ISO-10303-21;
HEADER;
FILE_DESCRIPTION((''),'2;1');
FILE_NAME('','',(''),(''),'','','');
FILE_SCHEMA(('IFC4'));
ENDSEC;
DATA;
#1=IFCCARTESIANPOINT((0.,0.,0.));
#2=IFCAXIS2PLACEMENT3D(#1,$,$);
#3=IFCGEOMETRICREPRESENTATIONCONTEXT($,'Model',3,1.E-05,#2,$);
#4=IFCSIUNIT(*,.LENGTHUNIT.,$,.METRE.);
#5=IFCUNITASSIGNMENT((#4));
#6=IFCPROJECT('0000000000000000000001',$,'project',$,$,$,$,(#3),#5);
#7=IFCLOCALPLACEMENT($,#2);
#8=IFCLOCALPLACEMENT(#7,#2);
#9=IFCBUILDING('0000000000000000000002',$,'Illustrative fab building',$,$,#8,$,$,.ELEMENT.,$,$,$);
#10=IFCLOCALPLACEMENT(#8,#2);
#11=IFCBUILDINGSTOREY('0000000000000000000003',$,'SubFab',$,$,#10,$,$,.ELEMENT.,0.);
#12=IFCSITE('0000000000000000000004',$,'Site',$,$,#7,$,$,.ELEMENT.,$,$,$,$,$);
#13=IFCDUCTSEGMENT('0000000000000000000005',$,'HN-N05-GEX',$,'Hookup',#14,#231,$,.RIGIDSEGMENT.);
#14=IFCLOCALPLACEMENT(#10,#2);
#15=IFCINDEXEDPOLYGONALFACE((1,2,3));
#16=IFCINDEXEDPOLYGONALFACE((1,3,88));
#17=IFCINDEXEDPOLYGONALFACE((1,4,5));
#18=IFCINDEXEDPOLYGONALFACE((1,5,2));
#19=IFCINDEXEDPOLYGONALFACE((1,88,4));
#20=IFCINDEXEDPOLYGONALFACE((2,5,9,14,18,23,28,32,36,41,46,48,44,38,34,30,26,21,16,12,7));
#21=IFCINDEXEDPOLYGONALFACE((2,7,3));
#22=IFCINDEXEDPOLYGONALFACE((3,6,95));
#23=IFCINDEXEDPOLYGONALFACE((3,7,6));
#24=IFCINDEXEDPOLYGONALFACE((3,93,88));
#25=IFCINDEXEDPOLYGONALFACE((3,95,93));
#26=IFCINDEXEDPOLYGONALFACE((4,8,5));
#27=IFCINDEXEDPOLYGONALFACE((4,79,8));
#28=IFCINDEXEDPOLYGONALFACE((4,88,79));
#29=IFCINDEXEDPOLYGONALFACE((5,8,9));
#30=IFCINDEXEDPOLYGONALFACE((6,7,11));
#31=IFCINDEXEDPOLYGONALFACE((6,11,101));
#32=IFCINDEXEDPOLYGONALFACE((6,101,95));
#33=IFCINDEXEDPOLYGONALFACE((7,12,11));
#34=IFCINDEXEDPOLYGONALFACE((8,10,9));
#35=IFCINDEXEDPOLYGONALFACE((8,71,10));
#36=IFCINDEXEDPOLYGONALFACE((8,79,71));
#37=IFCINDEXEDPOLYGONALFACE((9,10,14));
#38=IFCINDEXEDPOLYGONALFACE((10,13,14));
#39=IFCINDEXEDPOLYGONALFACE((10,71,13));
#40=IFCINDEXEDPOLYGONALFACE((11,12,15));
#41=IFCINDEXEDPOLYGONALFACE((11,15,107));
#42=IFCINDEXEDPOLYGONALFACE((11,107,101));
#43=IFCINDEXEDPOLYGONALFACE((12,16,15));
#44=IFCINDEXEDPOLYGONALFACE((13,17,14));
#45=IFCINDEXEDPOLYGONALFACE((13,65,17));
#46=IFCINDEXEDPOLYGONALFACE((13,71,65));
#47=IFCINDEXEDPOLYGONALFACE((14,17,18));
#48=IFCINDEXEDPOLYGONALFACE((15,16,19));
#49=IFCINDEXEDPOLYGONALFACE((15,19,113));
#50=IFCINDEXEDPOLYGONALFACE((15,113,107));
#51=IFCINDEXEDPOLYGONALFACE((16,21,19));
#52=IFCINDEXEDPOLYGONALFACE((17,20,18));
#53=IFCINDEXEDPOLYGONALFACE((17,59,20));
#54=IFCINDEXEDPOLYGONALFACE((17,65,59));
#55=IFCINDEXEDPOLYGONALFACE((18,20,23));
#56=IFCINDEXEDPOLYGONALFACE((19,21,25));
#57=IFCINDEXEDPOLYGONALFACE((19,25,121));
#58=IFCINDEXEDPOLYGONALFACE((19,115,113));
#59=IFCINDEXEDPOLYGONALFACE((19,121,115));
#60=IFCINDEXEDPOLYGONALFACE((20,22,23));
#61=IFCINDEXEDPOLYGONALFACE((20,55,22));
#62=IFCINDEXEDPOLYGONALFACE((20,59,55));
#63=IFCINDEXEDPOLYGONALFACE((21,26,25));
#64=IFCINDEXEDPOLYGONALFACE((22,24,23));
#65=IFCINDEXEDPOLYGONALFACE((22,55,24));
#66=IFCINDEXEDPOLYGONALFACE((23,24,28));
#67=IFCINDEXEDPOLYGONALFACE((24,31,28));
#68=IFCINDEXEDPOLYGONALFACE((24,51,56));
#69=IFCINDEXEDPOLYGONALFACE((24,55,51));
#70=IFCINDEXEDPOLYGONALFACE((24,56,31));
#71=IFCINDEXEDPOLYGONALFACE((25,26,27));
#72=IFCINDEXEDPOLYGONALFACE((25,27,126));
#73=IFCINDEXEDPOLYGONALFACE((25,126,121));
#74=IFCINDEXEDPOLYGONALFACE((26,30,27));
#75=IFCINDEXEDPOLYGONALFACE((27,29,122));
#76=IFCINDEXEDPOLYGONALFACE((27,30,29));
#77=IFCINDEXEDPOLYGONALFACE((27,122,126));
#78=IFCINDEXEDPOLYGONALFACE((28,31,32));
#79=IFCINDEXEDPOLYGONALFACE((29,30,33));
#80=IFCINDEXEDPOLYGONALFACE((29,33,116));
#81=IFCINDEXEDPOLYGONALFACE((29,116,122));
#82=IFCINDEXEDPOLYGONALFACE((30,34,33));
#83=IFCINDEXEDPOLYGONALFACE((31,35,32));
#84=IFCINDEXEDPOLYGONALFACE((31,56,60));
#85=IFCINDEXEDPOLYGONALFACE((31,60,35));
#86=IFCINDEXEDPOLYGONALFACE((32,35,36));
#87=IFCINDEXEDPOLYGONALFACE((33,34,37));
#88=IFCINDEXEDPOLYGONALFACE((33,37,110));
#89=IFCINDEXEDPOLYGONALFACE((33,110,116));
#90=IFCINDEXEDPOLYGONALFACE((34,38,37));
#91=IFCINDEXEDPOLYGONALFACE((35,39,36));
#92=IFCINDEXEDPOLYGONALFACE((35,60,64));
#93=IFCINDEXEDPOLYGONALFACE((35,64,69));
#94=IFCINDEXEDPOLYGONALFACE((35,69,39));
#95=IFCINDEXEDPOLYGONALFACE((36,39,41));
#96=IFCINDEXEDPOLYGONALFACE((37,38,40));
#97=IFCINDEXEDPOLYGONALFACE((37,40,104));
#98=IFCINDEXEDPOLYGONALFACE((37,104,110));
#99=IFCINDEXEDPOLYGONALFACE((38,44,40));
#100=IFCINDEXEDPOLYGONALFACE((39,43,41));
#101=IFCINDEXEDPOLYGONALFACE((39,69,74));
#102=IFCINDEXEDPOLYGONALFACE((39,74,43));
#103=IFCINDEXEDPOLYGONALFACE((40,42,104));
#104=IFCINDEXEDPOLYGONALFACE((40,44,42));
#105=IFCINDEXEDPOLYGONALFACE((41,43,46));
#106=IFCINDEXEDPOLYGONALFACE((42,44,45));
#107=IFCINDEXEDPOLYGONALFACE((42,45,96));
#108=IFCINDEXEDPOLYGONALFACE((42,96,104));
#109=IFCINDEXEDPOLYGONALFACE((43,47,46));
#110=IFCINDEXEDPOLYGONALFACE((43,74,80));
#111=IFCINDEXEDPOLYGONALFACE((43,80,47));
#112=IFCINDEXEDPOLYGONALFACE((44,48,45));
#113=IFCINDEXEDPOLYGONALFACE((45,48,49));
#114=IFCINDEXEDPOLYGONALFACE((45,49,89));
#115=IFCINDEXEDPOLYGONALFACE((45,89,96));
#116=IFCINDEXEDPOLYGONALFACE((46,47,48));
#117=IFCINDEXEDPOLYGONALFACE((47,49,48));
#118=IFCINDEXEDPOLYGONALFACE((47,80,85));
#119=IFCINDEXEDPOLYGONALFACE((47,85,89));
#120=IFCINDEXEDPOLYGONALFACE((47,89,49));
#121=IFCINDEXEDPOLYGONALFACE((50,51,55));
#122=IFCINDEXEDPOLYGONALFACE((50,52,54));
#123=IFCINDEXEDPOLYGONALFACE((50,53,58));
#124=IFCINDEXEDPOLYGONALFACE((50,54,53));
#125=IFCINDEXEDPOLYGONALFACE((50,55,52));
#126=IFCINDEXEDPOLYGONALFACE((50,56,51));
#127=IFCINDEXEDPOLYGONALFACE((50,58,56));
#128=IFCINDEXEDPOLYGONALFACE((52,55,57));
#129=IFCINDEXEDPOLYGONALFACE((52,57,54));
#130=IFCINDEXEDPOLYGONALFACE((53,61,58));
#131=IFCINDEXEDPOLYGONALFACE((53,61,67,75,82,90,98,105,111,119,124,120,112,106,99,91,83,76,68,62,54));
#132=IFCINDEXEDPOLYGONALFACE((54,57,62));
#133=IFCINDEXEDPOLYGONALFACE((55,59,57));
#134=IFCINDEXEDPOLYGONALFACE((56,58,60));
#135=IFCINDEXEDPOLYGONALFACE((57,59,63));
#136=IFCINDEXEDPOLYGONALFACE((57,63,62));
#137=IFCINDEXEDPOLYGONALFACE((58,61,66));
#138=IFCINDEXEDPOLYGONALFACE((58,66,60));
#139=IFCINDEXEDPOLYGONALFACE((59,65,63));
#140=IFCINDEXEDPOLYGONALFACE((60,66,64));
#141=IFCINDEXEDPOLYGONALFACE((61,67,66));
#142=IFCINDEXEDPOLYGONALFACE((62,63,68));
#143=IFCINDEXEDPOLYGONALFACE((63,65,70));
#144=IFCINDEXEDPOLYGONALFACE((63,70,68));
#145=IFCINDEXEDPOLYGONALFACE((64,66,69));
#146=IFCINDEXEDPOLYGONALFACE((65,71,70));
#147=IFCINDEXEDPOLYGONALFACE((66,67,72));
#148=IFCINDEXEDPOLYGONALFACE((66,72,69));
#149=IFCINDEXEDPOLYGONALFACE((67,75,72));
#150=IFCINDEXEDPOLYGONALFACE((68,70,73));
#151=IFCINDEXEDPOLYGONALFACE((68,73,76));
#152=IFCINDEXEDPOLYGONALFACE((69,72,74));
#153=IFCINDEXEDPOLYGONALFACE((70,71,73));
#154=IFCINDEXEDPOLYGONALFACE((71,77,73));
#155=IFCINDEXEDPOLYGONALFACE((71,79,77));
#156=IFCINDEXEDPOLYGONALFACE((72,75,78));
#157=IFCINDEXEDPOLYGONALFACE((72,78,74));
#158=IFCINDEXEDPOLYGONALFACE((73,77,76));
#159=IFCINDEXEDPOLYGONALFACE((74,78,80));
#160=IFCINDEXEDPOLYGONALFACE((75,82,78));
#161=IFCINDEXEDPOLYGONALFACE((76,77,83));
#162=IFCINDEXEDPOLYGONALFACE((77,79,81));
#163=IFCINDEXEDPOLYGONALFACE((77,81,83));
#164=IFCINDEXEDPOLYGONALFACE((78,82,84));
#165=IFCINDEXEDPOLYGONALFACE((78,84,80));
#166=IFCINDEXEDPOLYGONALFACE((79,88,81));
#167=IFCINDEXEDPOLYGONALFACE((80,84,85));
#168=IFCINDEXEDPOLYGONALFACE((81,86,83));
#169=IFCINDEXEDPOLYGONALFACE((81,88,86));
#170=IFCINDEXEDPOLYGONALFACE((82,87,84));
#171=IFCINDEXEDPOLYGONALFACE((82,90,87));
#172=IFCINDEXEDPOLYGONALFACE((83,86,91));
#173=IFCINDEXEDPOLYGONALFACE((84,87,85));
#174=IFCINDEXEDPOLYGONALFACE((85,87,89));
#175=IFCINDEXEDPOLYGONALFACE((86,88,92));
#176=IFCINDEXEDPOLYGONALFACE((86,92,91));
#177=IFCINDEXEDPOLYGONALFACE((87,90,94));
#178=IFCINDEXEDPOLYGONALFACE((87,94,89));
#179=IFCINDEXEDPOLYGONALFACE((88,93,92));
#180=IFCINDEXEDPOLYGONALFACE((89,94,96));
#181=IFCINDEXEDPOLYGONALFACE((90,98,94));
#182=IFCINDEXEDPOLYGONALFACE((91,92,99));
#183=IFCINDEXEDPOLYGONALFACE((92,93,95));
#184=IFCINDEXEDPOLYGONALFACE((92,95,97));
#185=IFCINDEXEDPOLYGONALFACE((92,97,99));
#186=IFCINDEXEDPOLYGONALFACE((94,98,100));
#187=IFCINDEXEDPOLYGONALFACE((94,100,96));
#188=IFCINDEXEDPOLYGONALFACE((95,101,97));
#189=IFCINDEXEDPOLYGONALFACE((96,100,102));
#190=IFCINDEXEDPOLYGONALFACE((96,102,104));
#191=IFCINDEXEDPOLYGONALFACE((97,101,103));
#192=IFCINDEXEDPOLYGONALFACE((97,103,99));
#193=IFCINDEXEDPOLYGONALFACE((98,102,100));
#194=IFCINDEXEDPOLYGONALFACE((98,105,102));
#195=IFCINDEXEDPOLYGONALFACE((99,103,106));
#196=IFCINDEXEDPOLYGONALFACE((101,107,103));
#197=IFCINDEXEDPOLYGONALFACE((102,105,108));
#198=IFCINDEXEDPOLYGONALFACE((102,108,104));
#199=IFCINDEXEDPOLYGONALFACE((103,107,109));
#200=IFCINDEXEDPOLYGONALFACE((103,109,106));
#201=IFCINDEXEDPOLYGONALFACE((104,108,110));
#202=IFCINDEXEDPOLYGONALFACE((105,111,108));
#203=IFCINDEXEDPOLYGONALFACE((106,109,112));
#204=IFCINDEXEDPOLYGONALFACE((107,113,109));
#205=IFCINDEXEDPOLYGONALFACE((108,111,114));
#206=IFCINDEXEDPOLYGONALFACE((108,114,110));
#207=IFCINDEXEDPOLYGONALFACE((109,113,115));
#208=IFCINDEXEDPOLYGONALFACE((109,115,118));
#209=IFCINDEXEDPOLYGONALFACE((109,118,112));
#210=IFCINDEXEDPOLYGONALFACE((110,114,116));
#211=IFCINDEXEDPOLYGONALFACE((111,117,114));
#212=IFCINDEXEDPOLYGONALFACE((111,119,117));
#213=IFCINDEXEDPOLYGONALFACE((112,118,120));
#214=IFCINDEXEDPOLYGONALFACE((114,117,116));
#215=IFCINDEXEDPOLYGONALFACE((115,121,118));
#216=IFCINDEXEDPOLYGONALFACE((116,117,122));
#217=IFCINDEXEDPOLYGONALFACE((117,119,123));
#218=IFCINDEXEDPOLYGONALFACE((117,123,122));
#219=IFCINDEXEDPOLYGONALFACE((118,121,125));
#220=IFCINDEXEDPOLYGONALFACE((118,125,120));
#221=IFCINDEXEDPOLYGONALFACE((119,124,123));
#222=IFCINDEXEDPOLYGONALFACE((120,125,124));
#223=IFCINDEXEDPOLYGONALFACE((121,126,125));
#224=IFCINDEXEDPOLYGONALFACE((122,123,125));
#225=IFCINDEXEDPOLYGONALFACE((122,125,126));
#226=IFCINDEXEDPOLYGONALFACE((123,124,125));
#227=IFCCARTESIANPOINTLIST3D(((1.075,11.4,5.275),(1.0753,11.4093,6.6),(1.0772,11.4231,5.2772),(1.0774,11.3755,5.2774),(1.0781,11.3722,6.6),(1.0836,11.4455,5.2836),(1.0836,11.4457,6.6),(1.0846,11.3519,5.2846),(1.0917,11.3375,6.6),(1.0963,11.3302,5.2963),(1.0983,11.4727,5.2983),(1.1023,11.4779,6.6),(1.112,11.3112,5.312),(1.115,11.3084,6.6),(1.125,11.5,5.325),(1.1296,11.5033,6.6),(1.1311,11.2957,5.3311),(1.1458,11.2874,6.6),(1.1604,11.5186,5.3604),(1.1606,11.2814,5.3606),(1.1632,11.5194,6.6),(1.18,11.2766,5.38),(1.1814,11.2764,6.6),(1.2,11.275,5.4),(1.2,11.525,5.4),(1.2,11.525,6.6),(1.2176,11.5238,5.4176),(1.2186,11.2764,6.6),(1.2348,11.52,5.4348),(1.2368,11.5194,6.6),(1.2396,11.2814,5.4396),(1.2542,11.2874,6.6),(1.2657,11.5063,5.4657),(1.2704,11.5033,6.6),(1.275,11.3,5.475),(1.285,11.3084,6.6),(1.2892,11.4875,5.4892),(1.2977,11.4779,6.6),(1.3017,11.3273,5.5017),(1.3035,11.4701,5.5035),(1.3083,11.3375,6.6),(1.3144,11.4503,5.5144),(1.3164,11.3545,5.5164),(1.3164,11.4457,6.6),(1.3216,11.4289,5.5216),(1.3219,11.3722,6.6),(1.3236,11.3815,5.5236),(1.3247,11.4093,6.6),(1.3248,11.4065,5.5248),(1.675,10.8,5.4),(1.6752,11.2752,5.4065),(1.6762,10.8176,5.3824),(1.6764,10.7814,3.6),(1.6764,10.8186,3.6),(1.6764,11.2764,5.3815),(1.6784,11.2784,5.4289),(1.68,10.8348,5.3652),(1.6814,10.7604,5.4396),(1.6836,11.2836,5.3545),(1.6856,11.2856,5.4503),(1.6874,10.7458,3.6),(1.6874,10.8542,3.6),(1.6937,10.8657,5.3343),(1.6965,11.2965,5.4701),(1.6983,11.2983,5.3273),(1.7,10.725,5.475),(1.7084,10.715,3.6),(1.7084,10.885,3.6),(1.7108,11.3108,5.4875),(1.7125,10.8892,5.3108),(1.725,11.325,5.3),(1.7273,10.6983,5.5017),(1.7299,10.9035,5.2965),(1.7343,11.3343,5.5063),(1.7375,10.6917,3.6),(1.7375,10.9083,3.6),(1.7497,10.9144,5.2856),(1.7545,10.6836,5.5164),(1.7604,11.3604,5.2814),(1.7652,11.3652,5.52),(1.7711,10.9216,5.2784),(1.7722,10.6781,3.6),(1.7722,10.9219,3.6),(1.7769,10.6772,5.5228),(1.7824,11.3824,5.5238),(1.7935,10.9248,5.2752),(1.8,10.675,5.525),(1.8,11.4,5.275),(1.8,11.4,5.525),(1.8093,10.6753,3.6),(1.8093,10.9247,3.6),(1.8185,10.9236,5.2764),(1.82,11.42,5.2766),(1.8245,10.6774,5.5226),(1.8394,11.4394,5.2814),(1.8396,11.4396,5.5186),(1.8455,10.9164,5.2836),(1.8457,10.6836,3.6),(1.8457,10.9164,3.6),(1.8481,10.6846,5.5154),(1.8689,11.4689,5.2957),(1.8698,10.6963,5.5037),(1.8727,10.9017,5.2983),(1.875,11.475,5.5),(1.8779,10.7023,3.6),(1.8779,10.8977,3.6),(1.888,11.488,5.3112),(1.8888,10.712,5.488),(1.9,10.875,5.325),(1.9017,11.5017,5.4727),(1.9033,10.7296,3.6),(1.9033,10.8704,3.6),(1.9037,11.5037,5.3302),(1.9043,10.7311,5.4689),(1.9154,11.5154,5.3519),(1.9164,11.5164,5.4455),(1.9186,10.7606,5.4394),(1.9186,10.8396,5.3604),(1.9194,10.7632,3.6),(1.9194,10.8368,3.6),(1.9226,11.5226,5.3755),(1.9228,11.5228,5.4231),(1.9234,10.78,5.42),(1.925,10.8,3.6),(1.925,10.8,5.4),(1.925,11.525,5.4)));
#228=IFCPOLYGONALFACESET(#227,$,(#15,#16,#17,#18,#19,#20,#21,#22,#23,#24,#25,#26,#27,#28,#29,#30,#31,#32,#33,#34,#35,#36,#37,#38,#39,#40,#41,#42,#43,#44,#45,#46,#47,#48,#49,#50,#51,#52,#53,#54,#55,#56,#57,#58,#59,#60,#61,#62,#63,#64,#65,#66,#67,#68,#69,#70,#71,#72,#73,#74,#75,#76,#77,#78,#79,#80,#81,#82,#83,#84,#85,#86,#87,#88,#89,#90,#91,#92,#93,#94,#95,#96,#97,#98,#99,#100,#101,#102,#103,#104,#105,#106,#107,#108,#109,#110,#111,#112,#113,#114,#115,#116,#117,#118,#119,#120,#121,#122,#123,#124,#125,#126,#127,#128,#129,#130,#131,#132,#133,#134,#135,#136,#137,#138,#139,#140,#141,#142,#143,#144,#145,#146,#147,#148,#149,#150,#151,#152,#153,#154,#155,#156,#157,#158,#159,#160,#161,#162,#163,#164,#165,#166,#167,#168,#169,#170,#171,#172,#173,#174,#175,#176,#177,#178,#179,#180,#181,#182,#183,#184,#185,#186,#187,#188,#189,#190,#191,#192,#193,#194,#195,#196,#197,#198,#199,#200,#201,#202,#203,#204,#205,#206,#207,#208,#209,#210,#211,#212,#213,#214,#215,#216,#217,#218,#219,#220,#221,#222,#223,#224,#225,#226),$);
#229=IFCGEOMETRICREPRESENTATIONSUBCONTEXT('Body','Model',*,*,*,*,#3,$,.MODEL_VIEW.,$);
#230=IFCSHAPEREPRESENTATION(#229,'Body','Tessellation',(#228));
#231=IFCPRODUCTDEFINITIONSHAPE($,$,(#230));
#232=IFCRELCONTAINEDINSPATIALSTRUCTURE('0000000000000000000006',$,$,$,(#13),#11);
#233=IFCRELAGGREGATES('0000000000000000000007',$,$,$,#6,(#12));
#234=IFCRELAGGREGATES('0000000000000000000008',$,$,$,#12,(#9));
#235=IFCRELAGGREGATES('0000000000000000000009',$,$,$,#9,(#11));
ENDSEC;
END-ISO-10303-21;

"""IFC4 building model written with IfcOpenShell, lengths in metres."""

from ifc_helpers import new_model, entity, si_unit, origin, place, context, subcontext, project, spatial, element, save


model = new_model("IFC4")

# Units and contexts
model_context = context("Model", 3, precision=1e-05, world=origin())
body_context = subcontext(model_context, "Body", "Model", "MODEL_VIEW")
ifc_project = project(units=[si_unit("LENGTHUNIT", "METRE")], contexts=[model_context])

# Site, building, storey
site_placement = place(None, origin())
site = spatial("IfcSite", under=ifc_project, at=site_placement, Name="Site", CompositionType="ELEMENT")
building_placement = place(site_placement, origin())
building = spatial("IfcBuilding", under=site, at=building_placement, Name="Illustrative fab building", CompositionType="ELEMENT")
storey_placement = place(building_placement, origin())
storey = spatial("IfcBuildingStorey", under=building, at=storey_placement, Name="SubFab", CompositionType="ELEMENT", Elevation=0.0)

# Duct segment
duct_segment_1_placement = place(storey_placement, origin())
element("IfcDuctSegment", 1, at=duct_segment_1_placement, inside=storey, Name="HN-N05-GEX", ObjectType="Hookup", PredefinedType="RIGIDSEGMENT", context=body_context, shape_type="AdvancedSweptSolid", body=[
    entity("IfcSweptDiskSolid", entity("IfcPolyline", [entity("IfcCartesianPoint", [1.8, 10.8, 3.6]), entity("IfcCartesianPoint", [1.8, 10.8, 5.4]), entity("IfcCartesianPoint", [1.8, 11.4, 5.4]), entity("IfcCartesianPoint", [1.2, 11.4, 5.4]), entity("IfcCartesianPoint", [1.2, 11.4, 6.6])]), 0.125),
])

save(model, "model.ifc")
